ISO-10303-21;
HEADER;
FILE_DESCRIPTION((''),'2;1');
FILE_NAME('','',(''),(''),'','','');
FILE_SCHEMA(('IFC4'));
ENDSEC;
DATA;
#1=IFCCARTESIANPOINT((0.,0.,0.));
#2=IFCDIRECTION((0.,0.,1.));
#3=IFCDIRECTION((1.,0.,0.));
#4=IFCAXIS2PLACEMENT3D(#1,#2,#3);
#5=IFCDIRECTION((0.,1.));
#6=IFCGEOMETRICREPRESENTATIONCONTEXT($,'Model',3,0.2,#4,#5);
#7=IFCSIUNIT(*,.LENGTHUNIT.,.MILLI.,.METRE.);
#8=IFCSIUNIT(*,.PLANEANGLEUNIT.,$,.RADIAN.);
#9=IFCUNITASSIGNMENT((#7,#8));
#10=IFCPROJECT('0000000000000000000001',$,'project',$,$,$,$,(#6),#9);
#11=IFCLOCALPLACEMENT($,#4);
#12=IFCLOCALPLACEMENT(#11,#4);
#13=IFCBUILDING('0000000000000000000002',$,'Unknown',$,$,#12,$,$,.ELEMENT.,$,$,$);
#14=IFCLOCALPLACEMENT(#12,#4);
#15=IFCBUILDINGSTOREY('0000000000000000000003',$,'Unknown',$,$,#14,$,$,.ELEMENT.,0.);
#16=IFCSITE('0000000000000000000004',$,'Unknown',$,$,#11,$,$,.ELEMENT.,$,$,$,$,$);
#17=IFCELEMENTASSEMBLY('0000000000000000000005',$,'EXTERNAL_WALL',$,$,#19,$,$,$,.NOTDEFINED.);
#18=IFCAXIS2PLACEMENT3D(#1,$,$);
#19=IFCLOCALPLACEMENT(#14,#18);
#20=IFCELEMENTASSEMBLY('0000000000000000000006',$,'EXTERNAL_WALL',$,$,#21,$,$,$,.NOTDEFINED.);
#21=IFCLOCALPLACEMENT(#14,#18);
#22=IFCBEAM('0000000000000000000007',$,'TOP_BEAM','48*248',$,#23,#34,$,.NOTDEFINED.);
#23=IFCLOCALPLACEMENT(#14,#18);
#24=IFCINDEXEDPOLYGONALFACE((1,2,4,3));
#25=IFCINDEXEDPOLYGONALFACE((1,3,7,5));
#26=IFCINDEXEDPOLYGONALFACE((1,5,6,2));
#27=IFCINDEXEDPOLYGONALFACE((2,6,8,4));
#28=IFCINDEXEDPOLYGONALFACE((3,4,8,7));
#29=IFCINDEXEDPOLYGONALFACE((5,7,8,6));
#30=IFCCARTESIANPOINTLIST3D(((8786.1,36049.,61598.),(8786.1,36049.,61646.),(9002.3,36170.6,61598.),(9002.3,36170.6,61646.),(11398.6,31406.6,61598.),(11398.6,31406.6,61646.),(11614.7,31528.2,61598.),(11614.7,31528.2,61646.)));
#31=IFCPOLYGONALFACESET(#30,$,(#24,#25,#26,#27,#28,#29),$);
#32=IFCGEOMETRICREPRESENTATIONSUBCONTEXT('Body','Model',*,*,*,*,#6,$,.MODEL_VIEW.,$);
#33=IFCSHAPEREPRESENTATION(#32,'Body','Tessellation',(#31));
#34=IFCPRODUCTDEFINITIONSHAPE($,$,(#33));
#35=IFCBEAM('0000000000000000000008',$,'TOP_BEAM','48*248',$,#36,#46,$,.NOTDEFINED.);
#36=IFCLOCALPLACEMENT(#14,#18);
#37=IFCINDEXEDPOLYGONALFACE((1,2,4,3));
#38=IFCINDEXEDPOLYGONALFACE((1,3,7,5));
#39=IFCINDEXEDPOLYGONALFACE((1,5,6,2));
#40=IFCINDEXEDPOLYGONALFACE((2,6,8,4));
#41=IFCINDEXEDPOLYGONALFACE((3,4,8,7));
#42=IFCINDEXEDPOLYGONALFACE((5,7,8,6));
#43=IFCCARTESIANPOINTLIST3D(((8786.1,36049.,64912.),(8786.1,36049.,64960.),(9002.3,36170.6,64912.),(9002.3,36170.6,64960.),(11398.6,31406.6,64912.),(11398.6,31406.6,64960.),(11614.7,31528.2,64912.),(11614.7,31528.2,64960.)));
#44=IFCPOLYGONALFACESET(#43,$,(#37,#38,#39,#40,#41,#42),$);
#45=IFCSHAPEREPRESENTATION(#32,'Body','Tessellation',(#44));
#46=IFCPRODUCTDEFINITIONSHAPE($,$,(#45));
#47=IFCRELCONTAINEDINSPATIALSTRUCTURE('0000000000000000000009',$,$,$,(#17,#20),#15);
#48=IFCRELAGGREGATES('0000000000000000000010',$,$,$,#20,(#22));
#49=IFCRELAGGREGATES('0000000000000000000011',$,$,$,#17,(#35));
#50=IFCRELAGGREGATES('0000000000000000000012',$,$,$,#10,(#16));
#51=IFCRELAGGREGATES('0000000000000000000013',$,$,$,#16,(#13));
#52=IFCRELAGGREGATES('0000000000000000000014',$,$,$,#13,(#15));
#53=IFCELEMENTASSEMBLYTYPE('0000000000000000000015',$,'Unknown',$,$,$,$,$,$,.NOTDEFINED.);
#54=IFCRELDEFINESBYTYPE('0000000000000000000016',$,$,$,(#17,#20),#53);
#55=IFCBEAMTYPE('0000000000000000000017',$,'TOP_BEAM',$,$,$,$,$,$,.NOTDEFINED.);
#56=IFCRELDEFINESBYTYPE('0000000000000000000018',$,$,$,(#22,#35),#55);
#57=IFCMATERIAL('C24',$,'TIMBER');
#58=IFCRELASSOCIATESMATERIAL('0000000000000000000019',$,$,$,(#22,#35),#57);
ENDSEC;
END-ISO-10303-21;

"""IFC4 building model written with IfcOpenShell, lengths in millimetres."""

from ifc_helpers import new_model, si_unit, direction, frame, origin_with_axes, origin_2d_with_axis, place, context, subcontext, project, spatial, rectangle, extrude, material, material_profile, profile_set, profile_usage, type_object, element, aggregate, save


model = new_model("IFC4")

# Units and contexts
model_context = context("Model", 3, precision=0.2, world=origin_with_axes(), true_north=direction((0.0, 1.0)))
body_context = subcontext(model_context, "Body", "Model", "MODEL_VIEW")
ifc_project = project(units=[si_unit("LENGTHUNIT", "METRE", prefix="MILLI"), si_unit("PLANEANGLEUNIT", "RADIAN")], contexts=[model_context])

# Site, building, storey
site_placement = place(None, origin_with_axes())
site = spatial("IfcSite", under=ifc_project, at=site_placement, Name="Unknown", CompositionType="ELEMENT")
building_placement = place(site_placement, origin_with_axes())
building = spatial("IfcBuilding", under=site, at=building_placement, Name="Unknown", CompositionType="ELEMENT")
storey_placement = place(building_placement, origin_with_axes())
storey = spatial("IfcBuildingStorey", under=building, at=storey_placement, Name="Unknown", CompositionType="ELEMENT", Elevation=0.0)

# Shared definitions
element_assembly_type = type_object("IfcElementAssemblyType", Name="Unknown", PredefinedType="NOTDEFINED")
ifc_material = material(Name="C24", Category="TIMBER")

# Element assemblies, beam
assembly_1_placement = place(storey_placement, frame((8894.2, 36109.8, 64936.0), z_axis=(-0.871487, -0.490418, 0.0), x_axis=(0.490421, -0.871485, 0.0)))
assembly_1 = element("IfcElementAssembly", 1, at=assembly_1_placement, inside=storey, type_object=element_assembly_type, Name="EXTERNAL_WALL", PredefinedType="NOTDEFINED")
ifc_material_profile_1 = material_profile(ifc_material, rectangle(XDim=248.0, YDim=48.0, at=origin_2d_with_axis()), Name="48*248")
ifc_profile_set_1 = profile_set([ifc_material_profile_1])
ifc_profile_usage_1 = profile_usage(ifc_profile_set_1, cardinal=3)
assembly_2_placement = place(storey_placement, frame((8894.2, 36109.8, 61622.0), z_axis=(-0.871487, -0.490418, 0.0), x_axis=(0.490421, -0.871485, 0.0)))
assembly_2 = element("IfcElementAssembly", 2, at=assembly_2_placement, inside=storey, type_object=element_assembly_type, Name="EXTERNAL_WALL", PredefinedType="NOTDEFINED")
beam_type_1 = type_object("IfcBeamType", Name="TOP_BEAM")
beam_1_placement = place(assembly_2_placement, origin_with_axes())
beam_1 = element("IfcBeam", 3, at=beam_1_placement, type_object=beam_type_1, material=ifc_profile_usage_1, Name="TOP_BEAM", Description="48*248", PredefinedType="NOTDEFINED", context=body_context, shape_type="SolidModel", body=[
    extrude(rectangle(XDim=248.0, YDim=48.0, at=origin_2d_with_axis()), frame((0.0, 0.0, 0.0), z_axis=(-1.0, 0.0, 0.0), x_axis=(0.0, 0.0, 1.0)), (0.0, 0.0, -1.0), 5327.0),
])
aggregate(assembly_2, [beam_1])

# Beam
beam_2_placement = place(assembly_1_placement, origin_with_axes())
beam_2 = element("IfcBeam", 4, at=beam_2_placement, type_object=beam_type_1, material=ifc_profile_usage_1, Name="TOP_BEAM", Description="48*248", PredefinedType="NOTDEFINED", context=body_context, shape_type="SolidModel", body=[
    extrude(rectangle(XDim=248.0, YDim=48.0, at=origin_2d_with_axis()), frame((0.0, 0.0, 0.0), z_axis=(-1.0, 0.0, 0.0), x_axis=(0.0, 0.0, 1.0)), (0.0, 0.0, -1.0), 5327.0),
])
aggregate(assembly_1, [beam_2])

save(model, "model.ifc")
